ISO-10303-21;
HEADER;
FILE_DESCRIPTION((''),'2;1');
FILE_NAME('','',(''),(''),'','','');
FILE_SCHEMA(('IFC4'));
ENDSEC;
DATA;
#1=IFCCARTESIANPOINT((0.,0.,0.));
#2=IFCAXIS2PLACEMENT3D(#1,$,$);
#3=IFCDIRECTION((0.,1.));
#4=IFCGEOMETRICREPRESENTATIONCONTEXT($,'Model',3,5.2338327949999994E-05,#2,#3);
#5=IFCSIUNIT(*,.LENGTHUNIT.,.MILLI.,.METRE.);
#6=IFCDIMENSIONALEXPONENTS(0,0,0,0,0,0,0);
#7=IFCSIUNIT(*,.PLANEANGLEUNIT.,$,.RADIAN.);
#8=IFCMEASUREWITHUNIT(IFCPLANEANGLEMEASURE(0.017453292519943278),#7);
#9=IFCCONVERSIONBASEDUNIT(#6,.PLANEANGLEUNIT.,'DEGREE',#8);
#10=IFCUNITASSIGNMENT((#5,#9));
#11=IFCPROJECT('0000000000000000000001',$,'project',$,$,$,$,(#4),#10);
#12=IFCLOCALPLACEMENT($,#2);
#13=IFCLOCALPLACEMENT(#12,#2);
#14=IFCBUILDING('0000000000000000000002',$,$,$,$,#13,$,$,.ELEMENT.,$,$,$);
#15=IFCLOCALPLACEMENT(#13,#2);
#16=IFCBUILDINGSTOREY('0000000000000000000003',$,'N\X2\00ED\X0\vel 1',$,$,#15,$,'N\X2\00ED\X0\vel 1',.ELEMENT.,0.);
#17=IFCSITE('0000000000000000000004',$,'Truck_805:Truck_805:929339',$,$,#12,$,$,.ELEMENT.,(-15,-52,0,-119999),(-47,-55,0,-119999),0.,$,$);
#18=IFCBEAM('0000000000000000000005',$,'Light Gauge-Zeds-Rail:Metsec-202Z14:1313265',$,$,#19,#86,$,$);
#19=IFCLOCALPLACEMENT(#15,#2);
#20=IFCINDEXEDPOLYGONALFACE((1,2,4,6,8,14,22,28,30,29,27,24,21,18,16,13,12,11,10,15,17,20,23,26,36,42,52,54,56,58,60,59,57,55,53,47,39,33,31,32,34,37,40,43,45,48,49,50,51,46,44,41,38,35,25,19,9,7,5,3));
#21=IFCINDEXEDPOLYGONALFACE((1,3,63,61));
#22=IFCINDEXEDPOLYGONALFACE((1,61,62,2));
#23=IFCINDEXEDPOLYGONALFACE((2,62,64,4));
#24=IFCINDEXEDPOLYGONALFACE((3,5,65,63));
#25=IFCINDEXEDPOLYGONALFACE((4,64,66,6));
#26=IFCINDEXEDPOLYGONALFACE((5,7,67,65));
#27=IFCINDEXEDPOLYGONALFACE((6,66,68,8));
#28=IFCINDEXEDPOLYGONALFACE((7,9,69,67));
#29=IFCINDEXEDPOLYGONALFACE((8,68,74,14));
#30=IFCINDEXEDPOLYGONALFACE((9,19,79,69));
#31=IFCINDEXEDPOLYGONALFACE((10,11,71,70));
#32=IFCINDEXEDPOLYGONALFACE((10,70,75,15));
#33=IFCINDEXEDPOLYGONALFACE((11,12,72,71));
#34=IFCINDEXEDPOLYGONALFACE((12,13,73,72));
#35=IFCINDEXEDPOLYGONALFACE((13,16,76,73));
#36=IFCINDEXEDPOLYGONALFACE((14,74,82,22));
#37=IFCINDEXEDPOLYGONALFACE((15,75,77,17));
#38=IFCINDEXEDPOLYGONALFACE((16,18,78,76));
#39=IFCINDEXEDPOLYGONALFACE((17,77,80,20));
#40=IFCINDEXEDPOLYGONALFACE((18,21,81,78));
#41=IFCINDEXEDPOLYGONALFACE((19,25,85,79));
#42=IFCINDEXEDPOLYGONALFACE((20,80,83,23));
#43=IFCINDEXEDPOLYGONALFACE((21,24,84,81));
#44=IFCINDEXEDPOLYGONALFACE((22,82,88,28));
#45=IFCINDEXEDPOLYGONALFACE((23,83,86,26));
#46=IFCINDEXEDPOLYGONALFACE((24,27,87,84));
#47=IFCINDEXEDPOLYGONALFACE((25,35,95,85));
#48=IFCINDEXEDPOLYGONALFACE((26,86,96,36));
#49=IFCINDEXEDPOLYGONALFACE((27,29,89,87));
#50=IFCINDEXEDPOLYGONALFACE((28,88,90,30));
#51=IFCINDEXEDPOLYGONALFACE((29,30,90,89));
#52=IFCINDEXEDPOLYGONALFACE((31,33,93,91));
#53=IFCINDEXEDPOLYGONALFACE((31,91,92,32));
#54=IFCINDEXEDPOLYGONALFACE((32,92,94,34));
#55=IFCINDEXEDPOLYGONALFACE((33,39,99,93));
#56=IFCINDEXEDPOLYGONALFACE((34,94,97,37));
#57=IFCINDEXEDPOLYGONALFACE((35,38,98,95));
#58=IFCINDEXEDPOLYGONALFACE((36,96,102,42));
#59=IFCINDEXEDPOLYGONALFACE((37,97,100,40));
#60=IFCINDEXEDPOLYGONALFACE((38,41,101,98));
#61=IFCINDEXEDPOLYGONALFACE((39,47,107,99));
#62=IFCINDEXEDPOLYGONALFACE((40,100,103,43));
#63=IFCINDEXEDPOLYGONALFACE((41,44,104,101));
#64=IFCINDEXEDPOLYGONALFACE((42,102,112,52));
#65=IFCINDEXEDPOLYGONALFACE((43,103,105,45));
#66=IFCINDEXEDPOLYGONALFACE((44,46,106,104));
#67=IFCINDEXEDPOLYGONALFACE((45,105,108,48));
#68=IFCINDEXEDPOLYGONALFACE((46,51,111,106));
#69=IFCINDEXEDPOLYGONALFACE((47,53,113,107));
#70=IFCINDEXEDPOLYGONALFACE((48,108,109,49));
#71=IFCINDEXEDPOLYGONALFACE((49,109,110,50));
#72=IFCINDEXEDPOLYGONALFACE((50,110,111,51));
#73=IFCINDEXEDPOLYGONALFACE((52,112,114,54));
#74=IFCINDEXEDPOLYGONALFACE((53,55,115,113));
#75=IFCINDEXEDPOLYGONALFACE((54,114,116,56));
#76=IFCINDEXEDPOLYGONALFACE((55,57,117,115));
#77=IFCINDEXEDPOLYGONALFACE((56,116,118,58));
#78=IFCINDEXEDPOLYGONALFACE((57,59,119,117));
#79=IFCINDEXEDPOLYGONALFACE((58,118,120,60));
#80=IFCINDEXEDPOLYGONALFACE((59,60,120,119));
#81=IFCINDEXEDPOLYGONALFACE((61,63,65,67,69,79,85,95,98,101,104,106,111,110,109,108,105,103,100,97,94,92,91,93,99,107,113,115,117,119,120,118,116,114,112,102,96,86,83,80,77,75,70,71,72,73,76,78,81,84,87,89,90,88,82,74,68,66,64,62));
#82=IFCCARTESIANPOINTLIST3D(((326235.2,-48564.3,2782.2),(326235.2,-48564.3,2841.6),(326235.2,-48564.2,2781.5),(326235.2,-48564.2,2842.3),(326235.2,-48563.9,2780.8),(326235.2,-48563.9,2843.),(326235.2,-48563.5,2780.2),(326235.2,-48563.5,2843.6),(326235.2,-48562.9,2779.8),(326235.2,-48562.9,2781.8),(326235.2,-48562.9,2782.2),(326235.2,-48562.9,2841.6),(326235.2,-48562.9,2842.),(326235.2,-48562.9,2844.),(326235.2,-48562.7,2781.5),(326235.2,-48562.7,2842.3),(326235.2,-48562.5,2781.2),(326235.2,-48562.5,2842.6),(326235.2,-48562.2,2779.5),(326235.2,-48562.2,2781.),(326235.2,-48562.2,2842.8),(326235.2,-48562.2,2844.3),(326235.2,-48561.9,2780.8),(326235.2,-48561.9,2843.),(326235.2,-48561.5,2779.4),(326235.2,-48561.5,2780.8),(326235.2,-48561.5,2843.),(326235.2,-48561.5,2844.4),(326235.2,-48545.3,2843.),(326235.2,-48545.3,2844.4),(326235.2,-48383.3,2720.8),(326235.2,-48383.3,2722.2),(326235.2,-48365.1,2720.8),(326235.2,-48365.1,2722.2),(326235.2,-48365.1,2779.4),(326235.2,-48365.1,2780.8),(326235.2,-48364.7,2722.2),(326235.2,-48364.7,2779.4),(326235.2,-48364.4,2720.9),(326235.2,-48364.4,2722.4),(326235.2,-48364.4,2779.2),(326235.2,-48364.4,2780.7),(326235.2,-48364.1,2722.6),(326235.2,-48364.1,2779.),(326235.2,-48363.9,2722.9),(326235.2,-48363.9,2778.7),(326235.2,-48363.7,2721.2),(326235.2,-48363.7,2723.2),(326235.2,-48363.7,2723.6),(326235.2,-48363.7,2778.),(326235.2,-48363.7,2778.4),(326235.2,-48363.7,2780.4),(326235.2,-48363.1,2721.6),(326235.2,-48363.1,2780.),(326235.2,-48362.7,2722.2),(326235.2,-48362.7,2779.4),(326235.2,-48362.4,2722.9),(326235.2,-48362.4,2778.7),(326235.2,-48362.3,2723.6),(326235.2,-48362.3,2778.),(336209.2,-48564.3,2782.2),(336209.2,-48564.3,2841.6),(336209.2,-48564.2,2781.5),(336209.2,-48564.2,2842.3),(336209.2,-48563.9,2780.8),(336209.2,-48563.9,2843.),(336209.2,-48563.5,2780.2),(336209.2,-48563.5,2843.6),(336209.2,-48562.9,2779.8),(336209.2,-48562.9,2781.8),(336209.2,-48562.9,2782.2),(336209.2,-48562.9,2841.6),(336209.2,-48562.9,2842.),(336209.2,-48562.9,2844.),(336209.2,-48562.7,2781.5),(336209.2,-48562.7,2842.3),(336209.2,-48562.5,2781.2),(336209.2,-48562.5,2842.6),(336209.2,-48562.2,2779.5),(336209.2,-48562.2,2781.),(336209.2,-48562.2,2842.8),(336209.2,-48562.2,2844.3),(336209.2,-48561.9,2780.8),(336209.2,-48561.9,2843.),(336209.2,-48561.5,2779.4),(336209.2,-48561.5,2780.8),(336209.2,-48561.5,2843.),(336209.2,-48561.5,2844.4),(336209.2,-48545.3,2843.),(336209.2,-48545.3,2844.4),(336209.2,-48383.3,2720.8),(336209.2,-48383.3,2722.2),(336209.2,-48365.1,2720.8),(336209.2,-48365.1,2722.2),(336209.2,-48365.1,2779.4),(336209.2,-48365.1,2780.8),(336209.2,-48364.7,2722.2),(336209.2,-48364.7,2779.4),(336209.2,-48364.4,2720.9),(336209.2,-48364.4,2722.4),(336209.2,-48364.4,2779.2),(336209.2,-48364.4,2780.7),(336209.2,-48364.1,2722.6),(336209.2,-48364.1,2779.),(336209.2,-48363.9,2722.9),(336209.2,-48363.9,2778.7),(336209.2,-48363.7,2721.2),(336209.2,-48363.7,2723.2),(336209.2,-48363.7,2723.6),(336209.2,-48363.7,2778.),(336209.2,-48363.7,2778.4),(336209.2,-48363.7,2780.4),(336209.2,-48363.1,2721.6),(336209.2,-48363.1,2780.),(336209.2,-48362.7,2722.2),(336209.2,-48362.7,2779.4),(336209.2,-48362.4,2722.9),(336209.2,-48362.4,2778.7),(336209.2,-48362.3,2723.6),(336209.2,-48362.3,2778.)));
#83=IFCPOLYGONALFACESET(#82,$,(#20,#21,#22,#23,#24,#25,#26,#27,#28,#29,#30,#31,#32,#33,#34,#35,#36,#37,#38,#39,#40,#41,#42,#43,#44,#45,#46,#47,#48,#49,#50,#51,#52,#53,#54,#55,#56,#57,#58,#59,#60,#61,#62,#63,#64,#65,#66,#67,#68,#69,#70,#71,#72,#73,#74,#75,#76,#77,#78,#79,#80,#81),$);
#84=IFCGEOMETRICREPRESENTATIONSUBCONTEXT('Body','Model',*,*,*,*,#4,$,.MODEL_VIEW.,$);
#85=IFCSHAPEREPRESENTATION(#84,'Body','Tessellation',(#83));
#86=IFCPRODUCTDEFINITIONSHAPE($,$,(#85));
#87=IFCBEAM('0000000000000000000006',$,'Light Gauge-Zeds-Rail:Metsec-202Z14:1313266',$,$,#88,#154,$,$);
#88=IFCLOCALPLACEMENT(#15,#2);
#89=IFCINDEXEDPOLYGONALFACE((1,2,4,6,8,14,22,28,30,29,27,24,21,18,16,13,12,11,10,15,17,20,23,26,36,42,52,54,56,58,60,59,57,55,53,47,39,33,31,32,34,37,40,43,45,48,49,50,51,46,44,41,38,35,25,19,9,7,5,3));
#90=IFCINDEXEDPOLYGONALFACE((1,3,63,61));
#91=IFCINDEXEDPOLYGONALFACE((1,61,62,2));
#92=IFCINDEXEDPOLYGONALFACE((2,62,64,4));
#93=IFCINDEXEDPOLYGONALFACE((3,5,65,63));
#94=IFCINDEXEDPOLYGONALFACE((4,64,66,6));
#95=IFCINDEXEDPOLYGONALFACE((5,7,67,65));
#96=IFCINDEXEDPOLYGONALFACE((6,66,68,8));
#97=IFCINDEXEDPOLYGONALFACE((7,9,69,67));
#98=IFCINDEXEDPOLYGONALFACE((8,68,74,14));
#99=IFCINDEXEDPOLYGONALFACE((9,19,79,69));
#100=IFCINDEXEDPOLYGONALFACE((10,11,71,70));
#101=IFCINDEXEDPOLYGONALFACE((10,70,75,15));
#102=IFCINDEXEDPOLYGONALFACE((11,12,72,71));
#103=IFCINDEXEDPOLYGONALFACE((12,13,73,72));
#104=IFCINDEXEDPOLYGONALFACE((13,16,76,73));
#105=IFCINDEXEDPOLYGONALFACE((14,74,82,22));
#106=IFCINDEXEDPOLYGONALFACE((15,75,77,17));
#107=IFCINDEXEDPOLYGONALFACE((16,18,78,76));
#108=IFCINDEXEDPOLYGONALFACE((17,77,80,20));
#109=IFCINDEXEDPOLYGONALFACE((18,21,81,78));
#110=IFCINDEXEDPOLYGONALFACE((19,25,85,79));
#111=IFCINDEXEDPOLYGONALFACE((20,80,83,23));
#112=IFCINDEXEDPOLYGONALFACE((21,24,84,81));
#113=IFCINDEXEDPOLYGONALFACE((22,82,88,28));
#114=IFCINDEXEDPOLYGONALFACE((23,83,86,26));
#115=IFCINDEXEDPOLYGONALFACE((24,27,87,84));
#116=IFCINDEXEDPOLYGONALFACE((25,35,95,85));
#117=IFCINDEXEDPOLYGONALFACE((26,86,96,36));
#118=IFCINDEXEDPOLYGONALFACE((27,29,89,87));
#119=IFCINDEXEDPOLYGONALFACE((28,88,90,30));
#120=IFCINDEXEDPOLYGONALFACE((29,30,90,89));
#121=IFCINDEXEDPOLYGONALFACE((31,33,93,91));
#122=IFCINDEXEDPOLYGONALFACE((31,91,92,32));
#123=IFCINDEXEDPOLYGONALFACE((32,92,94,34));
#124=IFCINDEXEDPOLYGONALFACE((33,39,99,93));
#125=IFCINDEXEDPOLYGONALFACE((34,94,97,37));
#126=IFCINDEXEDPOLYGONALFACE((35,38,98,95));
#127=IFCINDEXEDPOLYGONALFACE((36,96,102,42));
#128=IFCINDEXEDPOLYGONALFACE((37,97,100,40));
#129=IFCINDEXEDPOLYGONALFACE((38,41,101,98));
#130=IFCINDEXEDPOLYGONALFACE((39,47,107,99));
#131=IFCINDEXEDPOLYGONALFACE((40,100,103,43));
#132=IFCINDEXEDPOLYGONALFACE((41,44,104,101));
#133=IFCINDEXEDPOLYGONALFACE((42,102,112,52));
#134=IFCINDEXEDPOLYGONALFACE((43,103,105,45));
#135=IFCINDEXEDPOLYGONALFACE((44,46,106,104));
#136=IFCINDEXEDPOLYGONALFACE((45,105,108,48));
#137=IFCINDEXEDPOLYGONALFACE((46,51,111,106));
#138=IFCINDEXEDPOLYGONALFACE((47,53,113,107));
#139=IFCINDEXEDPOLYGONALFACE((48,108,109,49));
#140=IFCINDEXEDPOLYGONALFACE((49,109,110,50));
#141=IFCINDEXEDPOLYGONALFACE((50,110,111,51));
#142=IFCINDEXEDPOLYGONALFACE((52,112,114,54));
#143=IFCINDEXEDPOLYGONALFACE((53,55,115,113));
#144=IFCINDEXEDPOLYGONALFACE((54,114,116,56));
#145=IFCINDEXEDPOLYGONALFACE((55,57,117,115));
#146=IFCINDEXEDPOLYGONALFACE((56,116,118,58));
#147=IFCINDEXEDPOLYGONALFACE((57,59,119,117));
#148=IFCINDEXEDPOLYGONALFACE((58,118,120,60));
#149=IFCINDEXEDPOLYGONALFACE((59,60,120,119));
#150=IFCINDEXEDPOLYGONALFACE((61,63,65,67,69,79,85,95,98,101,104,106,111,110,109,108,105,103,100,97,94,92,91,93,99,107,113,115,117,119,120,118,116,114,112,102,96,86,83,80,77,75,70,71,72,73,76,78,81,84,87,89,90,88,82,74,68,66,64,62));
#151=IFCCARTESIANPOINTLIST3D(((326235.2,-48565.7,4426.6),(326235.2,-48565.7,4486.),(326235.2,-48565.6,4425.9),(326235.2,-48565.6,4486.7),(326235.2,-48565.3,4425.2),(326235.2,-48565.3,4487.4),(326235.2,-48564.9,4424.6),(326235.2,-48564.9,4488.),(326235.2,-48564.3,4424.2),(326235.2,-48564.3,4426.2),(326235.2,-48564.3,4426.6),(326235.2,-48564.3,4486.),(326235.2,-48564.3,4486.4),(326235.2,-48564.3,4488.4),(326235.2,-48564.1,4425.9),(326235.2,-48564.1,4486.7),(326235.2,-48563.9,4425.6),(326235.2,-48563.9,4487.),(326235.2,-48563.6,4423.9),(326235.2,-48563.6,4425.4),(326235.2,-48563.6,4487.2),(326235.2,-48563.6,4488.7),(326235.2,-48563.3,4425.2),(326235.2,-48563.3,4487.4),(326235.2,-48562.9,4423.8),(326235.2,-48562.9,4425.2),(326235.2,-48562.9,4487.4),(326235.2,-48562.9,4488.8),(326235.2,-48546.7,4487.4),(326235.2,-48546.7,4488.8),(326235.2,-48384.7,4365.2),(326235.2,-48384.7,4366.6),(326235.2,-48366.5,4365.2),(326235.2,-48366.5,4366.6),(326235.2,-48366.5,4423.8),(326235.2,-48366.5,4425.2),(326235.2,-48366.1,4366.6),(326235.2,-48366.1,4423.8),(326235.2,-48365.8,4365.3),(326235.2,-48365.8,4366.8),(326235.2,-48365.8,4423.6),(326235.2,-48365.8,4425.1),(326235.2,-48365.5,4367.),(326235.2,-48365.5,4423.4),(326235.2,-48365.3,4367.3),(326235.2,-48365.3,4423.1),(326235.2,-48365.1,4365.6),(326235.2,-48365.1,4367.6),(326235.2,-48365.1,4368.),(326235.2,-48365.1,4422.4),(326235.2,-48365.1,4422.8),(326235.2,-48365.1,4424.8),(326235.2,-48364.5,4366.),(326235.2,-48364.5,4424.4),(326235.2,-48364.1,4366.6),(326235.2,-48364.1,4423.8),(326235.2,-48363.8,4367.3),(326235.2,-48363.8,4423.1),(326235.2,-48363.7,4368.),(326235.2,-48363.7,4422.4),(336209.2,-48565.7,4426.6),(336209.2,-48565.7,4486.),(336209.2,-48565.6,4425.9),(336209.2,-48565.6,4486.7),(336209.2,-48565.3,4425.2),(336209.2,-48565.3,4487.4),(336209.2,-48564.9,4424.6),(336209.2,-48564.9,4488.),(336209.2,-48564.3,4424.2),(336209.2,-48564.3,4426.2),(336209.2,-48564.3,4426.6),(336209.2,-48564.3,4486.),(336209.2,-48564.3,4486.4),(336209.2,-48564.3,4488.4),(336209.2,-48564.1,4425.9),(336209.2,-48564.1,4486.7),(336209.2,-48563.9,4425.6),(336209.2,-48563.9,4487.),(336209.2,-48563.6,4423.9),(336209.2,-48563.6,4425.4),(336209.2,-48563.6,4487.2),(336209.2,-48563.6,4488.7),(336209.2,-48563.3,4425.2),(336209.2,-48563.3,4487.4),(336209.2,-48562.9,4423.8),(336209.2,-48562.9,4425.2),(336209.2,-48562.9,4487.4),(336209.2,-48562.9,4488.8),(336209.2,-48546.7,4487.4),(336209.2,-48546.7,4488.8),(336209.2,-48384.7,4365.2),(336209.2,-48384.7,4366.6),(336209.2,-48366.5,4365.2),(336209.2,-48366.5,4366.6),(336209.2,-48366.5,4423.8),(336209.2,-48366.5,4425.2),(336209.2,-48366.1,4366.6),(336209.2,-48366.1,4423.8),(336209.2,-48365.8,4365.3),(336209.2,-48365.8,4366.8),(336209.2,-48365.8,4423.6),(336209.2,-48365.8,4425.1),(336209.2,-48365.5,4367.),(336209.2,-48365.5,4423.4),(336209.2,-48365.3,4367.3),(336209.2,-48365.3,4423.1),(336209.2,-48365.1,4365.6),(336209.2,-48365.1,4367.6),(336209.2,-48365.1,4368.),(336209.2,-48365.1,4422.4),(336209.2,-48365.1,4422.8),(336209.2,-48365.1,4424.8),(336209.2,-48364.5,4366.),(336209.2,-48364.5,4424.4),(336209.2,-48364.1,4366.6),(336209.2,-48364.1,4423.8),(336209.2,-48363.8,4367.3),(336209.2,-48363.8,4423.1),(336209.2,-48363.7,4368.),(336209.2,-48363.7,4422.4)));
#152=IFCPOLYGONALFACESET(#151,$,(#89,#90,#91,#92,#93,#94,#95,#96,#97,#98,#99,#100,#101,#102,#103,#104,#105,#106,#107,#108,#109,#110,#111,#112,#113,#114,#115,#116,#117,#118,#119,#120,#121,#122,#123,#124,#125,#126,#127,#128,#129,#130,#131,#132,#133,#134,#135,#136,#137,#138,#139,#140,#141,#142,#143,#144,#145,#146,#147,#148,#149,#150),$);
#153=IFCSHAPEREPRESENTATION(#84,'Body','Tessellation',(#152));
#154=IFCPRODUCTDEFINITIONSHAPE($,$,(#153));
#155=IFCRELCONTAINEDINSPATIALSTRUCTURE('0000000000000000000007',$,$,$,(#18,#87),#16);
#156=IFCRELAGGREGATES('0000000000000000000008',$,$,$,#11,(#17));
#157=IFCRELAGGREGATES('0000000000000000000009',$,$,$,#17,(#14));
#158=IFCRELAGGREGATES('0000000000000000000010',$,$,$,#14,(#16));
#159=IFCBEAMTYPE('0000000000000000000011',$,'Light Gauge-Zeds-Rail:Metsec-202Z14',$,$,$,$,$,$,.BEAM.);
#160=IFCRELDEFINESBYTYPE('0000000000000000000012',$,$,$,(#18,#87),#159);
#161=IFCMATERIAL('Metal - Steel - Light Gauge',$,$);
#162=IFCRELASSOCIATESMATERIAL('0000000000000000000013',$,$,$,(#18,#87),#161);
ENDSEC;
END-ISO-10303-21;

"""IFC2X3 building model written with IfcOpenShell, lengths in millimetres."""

from ifc_helpers import new_model, entity, si_unit, converted_unit, direction, frame, frame_2d, origin, place, context, subcontext, project, spatial, polyline, circle_curve, parameter, trimmed, segment, composite_curve, outline, extrude, material, type_object, element, save


model = new_model("IFC2X3")

# Units and contexts
model_context = context("Model", 3, precision=5.2338327949999994e-05, world=origin(), true_north=direction((0.0, 1.0)))
body_context = subcontext(model_context, "Body", "Model", "MODEL_VIEW")
ifc_project = project(units=[si_unit("LENGTHUNIT", "METRE", prefix="MILLI"), converted_unit("PLANEANGLEUNIT", "DEGREE", entity("IfcPlaneAngleMeasure", 0.017453292519943278), si_unit("PLANEANGLEUNIT", "RADIAN"), dimensions=[0, 0, 0, 0, 0, 0, 0])], contexts=[model_context])

# Site, building, storey
site_placement = place(None, origin())
site = spatial("IfcSite", under=ifc_project, at=site_placement, Name="Truck_805:Truck_805:929339", CompositionType="ELEMENT", RefLatitude=(-15, -52, 0, -119999), RefLongitude=(-47, -55, 0, -119999), RefElevation=0.0)
building_placement = place(site_placement, origin())
building = spatial("IfcBuilding", under=site, at=building_placement, CompositionType="ELEMENT")
storey_placement = place(building_placement, origin())
storey = spatial("IfcBuildingStorey", under=building, at=storey_placement, Name="Nível 1", LongName="Nível 1", CompositionType="ELEMENT", Elevation=0.0)

# Beams
ifc_material_1 = material(Name="Metal - Steel - Light Gauge")
beam_type_1 = type_object("IfcBeamType", Name="Light Gauge-Zeds-Rail:Metsec-202Z14", PredefinedType="BEAM")
beam_1_placement = place(storey_placement, frame((326222.2, -48464.2, 2844.4)))
element("IfcBeam", 1, at=beam_1_placement, inside=storey, type_object=beam_type_1, material=ifc_material_1, Name="Light Gauge-Zeds-Rail:Metsec-202Z14:1313265", context=body_context, shape_type="SweptSolid", body=[
    extrude(outline(composite_curve([segment(polyline([(-60.0, -100.8), (-0.6, -100.8)]), True, "CONTINUOUS"), segment(trimmed(circle_curve(frame_2d((-0.6, -98.0), x_axis=(0.0, -1.0)), 2.8), [parameter(0.0)], [parameter(90.0)], True, "PARAMETER"), True, "CONTINUOUS"), segment(polyline([(2.2, -98.0), (2.2, 98.4)]), True, "CONTINUOUS"), segment(trimmed(circle_curve(frame_2d((3.6, 98.4), x_axis=(-1.0, 0.0)), 1.4), [parameter(270.0)], [parameter(0.0)], True, "PARAMETER"), False, "CONTINUOUS"), segment(polyline([(3.6, 99.8), (58.0, 99.8)]), True, "CONTINUOUS"), segment(trimmed(circle_curve(frame_2d((58.0, 98.4), x_axis=(0.0, 1.0)), 1.4), [parameter(270.0)], [parameter(0.0)], True, "PARAMETER"), False, "CONTINUOUS"), segment(polyline([(59.4, 98.4), (59.4, 80.2)]), True, "CONTINUOUS"), segment(polyline([(59.4, 80.2), (60.8, 80.2)]), True, "CONTINUOUS"), segment(polyline([(60.8, 80.2), (60.8, 98.4)]), True, "CONTINUOUS"), segment(trimmed(circle_curve(frame_2d((58.0, 98.4), x_axis=(1.0, 0.0)), 2.8), [parameter(0.0)], [parameter(90.0)], True, "PARAMETER"), True, "CONTINUOUS"), segment(polyline([(58.0, 101.2), (3.6, 101.2)]), True, "CONTINUOUS"), segment(trimmed(circle_curve(frame_2d((3.6, 98.4), x_axis=(0.0, 1.0)), 2.8), [parameter(0.0)], [parameter(90.0)], True, "PARAMETER"), True, "CONTINUOUS"), segment(polyline([(0.8, 98.4), (0.8, -98.0)]), True, "CONTINUOUS"), segment(trimmed(circle_curve(frame_2d((-0.6, -98.0), x_axis=(1.0, 0.0)), 1.4), [parameter(270.0)], [parameter(0.0)], True, "PARAMETER"), False, "CONTINUOUS"), segment(polyline([(-0.6, -99.4), (-60.0, -99.4)]), True, "CONTINUOUS"), segment(trimmed(circle_curve(frame_2d((-60.0, -98.0), x_axis=(0.0, -1.0)), 1.4), [parameter(270.0)], [parameter(0.0)], True, "PARAMETER"), False, "CONTINUOUS"), segment(polyline([(-61.4, -98.0), (-61.4, -81.8)]), True, "CONTINUOUS"), segment(polyline([(-61.4, -81.8), (-62.8, -81.8)]), True, "CONTINUOUS"), segment(polyline([(-62.8, -81.8), (-62.8, -98.0)]), True, "CONTINUOUS"), segment(trimmed(circle_curve(frame_2d((-60.0, -98.0), x_axis=(-1.0, 0.0)), 2.8), [parameter(0.0)], [parameter(90.0)], True, "PARAMETER"), True, "CONTINUOUS")], self_intersect=False)), frame((13.0, 0.7, -62.8), z_axis=(1.0, 0.0, 0.0), x_axis=(0.0, 0.0, -1.0)), (0.0, 0.0, 1.0), 9974.0),
])
beam_2_placement = place(storey_placement, frame((326222.2, -48465.6, 4488.8)))
element("IfcBeam", 2, at=beam_2_placement, inside=storey, type_object=beam_type_1, material=ifc_material_1, Name="Light Gauge-Zeds-Rail:Metsec-202Z14:1313266", context=body_context, shape_type="SweptSolid", body=[
    extrude(outline(composite_curve([segment(polyline([(-60.0, -100.8), (-0.6, -100.8)]), True, "CONTINUOUS"), segment(trimmed(circle_curve(frame_2d((-0.6, -98.0), x_axis=(0.0, -1.0)), 2.8), [parameter(0.0)], [parameter(90.0)], True, "PARAMETER"), True, "CONTINUOUS"), segment(polyline([(2.2, -98.0), (2.2, 98.4)]), True, "CONTINUOUS"), segment(trimmed(circle_curve(frame_2d((3.6, 98.4), x_axis=(-1.0, 0.0)), 1.4), [parameter(270.0)], [parameter(0.0)], True, "PARAMETER"), False, "CONTINUOUS"), segment(polyline([(3.6, 99.8), (58.0, 99.8)]), True, "CONTINUOUS"), segment(trimmed(circle_curve(frame_2d((58.0, 98.4), x_axis=(0.0, 1.0)), 1.4), [parameter(270.0)], [parameter(0.0)], True, "PARAMETER"), False, "CONTINUOUS"), segment(polyline([(59.4, 98.4), (59.4, 80.2)]), True, "CONTINUOUS"), segment(polyline([(59.4, 80.2), (60.8, 80.2)]), True, "CONTINUOUS"), segment(polyline([(60.8, 80.2), (60.8, 98.4)]), True, "CONTINUOUS"), segment(trimmed(circle_curve(frame_2d((58.0, 98.4), x_axis=(1.0, 0.0)), 2.8), [parameter(0.0)], [parameter(90.0)], True, "PARAMETER"), True, "CONTINUOUS"), segment(polyline([(58.0, 101.2), (3.6, 101.2)]), True, "CONTINUOUS"), segment(trimmed(circle_curve(frame_2d((3.6, 98.4), x_axis=(0.0, 1.0)), 2.8), [parameter(0.0)], [parameter(90.0)], True, "PARAMETER"), True, "CONTINUOUS"), segment(polyline([(0.8, 98.4), (0.8, -98.0)]), True, "CONTINUOUS"), segment(trimmed(circle_curve(frame_2d((-0.6, -98.0), x_axis=(1.0, 0.0)), 1.4), [parameter(270.0)], [parameter(0.0)], True, "PARAMETER"), False, "CONTINUOUS"), segment(polyline([(-0.6, -99.4), (-60.0, -99.4)]), True, "CONTINUOUS"), segment(trimmed(circle_curve(frame_2d((-60.0, -98.0), x_axis=(0.0, -1.0)), 1.4), [parameter(270.0)], [parameter(0.0)], True, "PARAMETER"), False, "CONTINUOUS"), segment(polyline([(-61.4, -98.0), (-61.4, -81.8)]), True, "CONTINUOUS"), segment(polyline([(-61.4, -81.8), (-62.8, -81.8)]), True, "CONTINUOUS"), segment(polyline([(-62.8, -81.8), (-62.8, -98.0)]), True, "CONTINUOUS"), segment(trimmed(circle_curve(frame_2d((-60.0, -98.0), x_axis=(-1.0, 0.0)), 2.8), [parameter(0.0)], [parameter(90.0)], True, "PARAMETER"), True, "CONTINUOUS")], self_intersect=False)), frame((13.0, 0.7, -62.8), z_axis=(1.0, 0.0, 0.0), x_axis=(0.0, 0.0, -1.0)), (0.0, 0.0, 1.0), 9974.0),
])

save(model, "model.ifc")
